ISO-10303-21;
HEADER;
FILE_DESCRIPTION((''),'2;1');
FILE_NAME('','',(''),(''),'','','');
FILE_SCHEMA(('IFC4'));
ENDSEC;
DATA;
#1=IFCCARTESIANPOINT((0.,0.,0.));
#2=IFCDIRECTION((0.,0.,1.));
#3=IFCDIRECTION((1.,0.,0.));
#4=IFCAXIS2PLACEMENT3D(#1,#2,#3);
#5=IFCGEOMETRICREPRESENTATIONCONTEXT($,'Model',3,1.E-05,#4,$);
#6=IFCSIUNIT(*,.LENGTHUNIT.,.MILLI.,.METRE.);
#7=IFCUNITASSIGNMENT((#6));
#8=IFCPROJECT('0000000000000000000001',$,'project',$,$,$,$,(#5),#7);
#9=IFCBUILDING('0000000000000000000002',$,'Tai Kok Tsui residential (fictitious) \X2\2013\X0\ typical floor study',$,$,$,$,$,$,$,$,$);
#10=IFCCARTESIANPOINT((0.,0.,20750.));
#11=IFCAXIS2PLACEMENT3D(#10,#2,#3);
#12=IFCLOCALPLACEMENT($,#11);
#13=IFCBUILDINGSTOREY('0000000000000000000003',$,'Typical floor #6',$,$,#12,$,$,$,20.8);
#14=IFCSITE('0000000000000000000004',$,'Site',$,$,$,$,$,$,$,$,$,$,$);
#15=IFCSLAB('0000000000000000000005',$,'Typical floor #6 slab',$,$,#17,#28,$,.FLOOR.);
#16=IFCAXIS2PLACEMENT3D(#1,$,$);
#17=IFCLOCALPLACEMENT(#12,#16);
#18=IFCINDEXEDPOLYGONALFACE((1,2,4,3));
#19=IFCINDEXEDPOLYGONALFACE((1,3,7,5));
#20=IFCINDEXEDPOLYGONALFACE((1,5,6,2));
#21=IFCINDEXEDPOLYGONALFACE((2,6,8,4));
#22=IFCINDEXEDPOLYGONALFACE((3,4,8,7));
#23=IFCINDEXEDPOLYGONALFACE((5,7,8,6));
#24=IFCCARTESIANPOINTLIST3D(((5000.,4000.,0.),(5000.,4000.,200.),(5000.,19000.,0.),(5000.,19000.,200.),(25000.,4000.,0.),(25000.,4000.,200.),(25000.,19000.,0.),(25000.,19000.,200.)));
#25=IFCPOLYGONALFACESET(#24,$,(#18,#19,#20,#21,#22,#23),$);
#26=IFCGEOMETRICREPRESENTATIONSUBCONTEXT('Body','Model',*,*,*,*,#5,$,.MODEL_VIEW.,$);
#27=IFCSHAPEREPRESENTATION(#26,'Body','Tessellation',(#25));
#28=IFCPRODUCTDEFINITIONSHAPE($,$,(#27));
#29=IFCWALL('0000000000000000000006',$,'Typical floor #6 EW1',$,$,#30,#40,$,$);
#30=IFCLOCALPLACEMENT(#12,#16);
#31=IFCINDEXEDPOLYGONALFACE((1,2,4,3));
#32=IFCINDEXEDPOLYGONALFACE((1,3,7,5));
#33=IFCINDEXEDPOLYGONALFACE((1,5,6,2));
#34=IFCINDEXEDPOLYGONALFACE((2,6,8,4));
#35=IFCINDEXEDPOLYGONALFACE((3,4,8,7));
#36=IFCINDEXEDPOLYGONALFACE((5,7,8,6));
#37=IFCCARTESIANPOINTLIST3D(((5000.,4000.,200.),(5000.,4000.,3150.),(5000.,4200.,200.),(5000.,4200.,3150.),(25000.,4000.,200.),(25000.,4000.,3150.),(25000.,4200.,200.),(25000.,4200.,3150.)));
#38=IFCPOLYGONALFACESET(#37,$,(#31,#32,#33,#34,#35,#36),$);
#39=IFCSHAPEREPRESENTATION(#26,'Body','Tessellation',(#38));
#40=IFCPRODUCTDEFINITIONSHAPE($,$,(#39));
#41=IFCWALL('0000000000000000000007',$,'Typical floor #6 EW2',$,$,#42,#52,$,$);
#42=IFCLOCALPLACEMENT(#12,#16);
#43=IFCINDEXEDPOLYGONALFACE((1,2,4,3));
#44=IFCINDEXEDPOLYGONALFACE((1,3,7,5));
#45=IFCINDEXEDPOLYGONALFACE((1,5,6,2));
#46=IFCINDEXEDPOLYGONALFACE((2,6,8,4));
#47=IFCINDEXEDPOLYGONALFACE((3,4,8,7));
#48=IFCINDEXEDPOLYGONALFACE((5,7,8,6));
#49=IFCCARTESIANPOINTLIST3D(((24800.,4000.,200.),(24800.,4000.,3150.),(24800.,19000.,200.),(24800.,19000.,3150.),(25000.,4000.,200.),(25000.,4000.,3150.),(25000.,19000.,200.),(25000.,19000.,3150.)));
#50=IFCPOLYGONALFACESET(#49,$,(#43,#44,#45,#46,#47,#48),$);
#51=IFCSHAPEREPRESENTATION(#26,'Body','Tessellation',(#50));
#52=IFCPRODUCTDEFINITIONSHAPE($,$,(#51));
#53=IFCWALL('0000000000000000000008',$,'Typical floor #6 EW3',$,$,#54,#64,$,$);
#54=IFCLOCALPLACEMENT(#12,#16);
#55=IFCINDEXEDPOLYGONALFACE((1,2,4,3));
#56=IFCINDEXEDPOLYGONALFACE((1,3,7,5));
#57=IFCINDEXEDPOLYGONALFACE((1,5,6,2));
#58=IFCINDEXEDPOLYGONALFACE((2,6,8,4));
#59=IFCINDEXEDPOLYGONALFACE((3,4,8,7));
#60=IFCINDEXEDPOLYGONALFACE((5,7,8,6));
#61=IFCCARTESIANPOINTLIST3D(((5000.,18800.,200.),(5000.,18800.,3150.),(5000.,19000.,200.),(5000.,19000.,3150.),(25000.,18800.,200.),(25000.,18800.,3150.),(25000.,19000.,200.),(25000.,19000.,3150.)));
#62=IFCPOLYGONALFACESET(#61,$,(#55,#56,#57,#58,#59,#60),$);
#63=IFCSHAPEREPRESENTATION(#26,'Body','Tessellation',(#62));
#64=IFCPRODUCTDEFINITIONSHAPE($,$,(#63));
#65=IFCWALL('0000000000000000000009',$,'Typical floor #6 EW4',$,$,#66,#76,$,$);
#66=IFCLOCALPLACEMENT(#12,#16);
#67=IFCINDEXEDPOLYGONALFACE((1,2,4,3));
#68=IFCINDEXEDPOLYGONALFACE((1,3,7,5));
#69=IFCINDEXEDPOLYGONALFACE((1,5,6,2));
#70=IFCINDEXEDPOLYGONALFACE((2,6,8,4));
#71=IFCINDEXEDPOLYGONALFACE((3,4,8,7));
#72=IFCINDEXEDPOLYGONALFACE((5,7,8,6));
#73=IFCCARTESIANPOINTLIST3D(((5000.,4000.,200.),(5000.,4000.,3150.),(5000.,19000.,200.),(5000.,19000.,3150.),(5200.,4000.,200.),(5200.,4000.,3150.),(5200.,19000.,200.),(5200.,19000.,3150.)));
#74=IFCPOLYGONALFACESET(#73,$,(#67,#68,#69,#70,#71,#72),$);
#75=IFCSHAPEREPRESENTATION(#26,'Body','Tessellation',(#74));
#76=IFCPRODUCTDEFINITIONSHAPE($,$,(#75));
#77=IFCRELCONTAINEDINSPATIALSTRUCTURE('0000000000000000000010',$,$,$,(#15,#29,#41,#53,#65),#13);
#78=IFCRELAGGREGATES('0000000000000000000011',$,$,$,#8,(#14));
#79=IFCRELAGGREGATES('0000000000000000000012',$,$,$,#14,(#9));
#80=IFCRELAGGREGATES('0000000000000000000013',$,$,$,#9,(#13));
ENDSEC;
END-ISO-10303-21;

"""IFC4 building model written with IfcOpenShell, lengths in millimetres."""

from ifc_helpers import new_model, si_unit, frame, origin_with_axes, place, context, subcontext, project, spatial, indexed_curve, outline, extrude, element, save


model = new_model("IFC4")

# Units and contexts
model_context = context("Model", 3, precision=1e-05, world=origin_with_axes())
body_context = subcontext(model_context, "Body", "Model", "MODEL_VIEW")
ifc_project = project(units=[si_unit("LENGTHUNIT", "METRE", prefix="MILLI")], contexts=[model_context])

# Site, building, storey
site = spatial("IfcSite", under=ifc_project, Name="Site")
building = spatial("IfcBuilding", under=site, Name="Tai Kok Tsui residential (fictitious) – typical floor study")
storey_placement = place(None, frame((0.0, 0.0, 20750.0), z_axis=(0.0, 0.0, 1.0), x_axis=(1.0, 0.0, 0.0)))
storey = spatial("IfcBuildingStorey", under=building, at=storey_placement, Name="Typical floor #6", Elevation=20.8)

# Slab
slab_placement = place(storey_placement, origin_with_axes())
element("IfcSlab", 1, at=slab_placement, inside=storey, Name="Typical floor #6 slab", PredefinedType="FLOOR", context=body_context, shape_type="SweptSolid", body=[
    extrude(outline(indexed_curve([(5000.0, 4000.0), (25000.0, 4000.0), (25000.0, 19000.0), (5000.0, 19000.0)])), None, (0.0, 0.0, 1.0), 200.0),
])

# Walls
wall_1_placement = place(storey_placement, frame((5000.0, 4000.0, 200.0), z_axis=(0.0, 0.0, 1.0), x_axis=(1.0, 0.0, 0.0)))
element("IfcWall", 2, at=wall_1_placement, inside=storey, Name="Typical floor #6 EW1", context=body_context, shape_type="SweptSolid", body=[
    extrude(outline(indexed_curve([(0.0, 0.0), (0.0, 200.0), (20000.0, 200.0), (20000.0, 0.0), (0.0, 0.0)], self_intersect=False)), origin_with_axes(), (0.0, 0.0, 1.0), 2950.0),
])
wall_2_placement = place(storey_placement, frame((25000.0, 4000.0, 200.0), z_axis=(0.0, 0.0, 1.0), x_axis=(0.0, 1.0, 0.0)))
element("IfcWall", 3, at=wall_2_placement, inside=storey, Name="Typical floor #6 EW2", context=body_context, shape_type="SweptSolid", body=[
    extrude(outline(indexed_curve([(0.0, 0.0), (0.0, 200.0), (15000.0, 200.0), (15000.0, 0.0), (0.0, 0.0)], self_intersect=False)), origin_with_axes(), (0.0, 0.0, 1.0), 2950.0),
])
wall_3_placement = place(storey_placement, frame((25000.0, 19000.0, 200.0), z_axis=(0.0, 0.0, 1.0), x_axis=(-1.0, 0.0, 0.0)))
element("IfcWall", 4, at=wall_3_placement, inside=storey, Name="Typical floor #6 EW3", context=body_context, shape_type="SweptSolid", body=[
    extrude(outline(indexed_curve([(0.0, 0.0), (0.0, 200.0), (20000.0, 200.0), (20000.0, 0.0), (0.0, 0.0)], self_intersect=False)), origin_with_axes(), (0.0, 0.0, 1.0), 2950.0),
])
wall_4_placement = place(storey_placement, frame((5000.0, 19000.0, 200.0), z_axis=(0.0, 0.0, 1.0), x_axis=(0.0, -1.0, 0.0)))
element("IfcWall", 5, at=wall_4_placement, inside=storey, Name="Typical floor #6 EW4", context=body_context, shape_type="SweptSolid", body=[
    extrude(outline(indexed_curve([(0.0, 0.0), (0.0, 200.0), (15000.0, 200.0), (15000.0, 0.0), (0.0, 0.0)], self_intersect=False)), origin_with_axes(), (0.0, 0.0, 1.0), 2950.0),
])

save(model, "model.ifc")
